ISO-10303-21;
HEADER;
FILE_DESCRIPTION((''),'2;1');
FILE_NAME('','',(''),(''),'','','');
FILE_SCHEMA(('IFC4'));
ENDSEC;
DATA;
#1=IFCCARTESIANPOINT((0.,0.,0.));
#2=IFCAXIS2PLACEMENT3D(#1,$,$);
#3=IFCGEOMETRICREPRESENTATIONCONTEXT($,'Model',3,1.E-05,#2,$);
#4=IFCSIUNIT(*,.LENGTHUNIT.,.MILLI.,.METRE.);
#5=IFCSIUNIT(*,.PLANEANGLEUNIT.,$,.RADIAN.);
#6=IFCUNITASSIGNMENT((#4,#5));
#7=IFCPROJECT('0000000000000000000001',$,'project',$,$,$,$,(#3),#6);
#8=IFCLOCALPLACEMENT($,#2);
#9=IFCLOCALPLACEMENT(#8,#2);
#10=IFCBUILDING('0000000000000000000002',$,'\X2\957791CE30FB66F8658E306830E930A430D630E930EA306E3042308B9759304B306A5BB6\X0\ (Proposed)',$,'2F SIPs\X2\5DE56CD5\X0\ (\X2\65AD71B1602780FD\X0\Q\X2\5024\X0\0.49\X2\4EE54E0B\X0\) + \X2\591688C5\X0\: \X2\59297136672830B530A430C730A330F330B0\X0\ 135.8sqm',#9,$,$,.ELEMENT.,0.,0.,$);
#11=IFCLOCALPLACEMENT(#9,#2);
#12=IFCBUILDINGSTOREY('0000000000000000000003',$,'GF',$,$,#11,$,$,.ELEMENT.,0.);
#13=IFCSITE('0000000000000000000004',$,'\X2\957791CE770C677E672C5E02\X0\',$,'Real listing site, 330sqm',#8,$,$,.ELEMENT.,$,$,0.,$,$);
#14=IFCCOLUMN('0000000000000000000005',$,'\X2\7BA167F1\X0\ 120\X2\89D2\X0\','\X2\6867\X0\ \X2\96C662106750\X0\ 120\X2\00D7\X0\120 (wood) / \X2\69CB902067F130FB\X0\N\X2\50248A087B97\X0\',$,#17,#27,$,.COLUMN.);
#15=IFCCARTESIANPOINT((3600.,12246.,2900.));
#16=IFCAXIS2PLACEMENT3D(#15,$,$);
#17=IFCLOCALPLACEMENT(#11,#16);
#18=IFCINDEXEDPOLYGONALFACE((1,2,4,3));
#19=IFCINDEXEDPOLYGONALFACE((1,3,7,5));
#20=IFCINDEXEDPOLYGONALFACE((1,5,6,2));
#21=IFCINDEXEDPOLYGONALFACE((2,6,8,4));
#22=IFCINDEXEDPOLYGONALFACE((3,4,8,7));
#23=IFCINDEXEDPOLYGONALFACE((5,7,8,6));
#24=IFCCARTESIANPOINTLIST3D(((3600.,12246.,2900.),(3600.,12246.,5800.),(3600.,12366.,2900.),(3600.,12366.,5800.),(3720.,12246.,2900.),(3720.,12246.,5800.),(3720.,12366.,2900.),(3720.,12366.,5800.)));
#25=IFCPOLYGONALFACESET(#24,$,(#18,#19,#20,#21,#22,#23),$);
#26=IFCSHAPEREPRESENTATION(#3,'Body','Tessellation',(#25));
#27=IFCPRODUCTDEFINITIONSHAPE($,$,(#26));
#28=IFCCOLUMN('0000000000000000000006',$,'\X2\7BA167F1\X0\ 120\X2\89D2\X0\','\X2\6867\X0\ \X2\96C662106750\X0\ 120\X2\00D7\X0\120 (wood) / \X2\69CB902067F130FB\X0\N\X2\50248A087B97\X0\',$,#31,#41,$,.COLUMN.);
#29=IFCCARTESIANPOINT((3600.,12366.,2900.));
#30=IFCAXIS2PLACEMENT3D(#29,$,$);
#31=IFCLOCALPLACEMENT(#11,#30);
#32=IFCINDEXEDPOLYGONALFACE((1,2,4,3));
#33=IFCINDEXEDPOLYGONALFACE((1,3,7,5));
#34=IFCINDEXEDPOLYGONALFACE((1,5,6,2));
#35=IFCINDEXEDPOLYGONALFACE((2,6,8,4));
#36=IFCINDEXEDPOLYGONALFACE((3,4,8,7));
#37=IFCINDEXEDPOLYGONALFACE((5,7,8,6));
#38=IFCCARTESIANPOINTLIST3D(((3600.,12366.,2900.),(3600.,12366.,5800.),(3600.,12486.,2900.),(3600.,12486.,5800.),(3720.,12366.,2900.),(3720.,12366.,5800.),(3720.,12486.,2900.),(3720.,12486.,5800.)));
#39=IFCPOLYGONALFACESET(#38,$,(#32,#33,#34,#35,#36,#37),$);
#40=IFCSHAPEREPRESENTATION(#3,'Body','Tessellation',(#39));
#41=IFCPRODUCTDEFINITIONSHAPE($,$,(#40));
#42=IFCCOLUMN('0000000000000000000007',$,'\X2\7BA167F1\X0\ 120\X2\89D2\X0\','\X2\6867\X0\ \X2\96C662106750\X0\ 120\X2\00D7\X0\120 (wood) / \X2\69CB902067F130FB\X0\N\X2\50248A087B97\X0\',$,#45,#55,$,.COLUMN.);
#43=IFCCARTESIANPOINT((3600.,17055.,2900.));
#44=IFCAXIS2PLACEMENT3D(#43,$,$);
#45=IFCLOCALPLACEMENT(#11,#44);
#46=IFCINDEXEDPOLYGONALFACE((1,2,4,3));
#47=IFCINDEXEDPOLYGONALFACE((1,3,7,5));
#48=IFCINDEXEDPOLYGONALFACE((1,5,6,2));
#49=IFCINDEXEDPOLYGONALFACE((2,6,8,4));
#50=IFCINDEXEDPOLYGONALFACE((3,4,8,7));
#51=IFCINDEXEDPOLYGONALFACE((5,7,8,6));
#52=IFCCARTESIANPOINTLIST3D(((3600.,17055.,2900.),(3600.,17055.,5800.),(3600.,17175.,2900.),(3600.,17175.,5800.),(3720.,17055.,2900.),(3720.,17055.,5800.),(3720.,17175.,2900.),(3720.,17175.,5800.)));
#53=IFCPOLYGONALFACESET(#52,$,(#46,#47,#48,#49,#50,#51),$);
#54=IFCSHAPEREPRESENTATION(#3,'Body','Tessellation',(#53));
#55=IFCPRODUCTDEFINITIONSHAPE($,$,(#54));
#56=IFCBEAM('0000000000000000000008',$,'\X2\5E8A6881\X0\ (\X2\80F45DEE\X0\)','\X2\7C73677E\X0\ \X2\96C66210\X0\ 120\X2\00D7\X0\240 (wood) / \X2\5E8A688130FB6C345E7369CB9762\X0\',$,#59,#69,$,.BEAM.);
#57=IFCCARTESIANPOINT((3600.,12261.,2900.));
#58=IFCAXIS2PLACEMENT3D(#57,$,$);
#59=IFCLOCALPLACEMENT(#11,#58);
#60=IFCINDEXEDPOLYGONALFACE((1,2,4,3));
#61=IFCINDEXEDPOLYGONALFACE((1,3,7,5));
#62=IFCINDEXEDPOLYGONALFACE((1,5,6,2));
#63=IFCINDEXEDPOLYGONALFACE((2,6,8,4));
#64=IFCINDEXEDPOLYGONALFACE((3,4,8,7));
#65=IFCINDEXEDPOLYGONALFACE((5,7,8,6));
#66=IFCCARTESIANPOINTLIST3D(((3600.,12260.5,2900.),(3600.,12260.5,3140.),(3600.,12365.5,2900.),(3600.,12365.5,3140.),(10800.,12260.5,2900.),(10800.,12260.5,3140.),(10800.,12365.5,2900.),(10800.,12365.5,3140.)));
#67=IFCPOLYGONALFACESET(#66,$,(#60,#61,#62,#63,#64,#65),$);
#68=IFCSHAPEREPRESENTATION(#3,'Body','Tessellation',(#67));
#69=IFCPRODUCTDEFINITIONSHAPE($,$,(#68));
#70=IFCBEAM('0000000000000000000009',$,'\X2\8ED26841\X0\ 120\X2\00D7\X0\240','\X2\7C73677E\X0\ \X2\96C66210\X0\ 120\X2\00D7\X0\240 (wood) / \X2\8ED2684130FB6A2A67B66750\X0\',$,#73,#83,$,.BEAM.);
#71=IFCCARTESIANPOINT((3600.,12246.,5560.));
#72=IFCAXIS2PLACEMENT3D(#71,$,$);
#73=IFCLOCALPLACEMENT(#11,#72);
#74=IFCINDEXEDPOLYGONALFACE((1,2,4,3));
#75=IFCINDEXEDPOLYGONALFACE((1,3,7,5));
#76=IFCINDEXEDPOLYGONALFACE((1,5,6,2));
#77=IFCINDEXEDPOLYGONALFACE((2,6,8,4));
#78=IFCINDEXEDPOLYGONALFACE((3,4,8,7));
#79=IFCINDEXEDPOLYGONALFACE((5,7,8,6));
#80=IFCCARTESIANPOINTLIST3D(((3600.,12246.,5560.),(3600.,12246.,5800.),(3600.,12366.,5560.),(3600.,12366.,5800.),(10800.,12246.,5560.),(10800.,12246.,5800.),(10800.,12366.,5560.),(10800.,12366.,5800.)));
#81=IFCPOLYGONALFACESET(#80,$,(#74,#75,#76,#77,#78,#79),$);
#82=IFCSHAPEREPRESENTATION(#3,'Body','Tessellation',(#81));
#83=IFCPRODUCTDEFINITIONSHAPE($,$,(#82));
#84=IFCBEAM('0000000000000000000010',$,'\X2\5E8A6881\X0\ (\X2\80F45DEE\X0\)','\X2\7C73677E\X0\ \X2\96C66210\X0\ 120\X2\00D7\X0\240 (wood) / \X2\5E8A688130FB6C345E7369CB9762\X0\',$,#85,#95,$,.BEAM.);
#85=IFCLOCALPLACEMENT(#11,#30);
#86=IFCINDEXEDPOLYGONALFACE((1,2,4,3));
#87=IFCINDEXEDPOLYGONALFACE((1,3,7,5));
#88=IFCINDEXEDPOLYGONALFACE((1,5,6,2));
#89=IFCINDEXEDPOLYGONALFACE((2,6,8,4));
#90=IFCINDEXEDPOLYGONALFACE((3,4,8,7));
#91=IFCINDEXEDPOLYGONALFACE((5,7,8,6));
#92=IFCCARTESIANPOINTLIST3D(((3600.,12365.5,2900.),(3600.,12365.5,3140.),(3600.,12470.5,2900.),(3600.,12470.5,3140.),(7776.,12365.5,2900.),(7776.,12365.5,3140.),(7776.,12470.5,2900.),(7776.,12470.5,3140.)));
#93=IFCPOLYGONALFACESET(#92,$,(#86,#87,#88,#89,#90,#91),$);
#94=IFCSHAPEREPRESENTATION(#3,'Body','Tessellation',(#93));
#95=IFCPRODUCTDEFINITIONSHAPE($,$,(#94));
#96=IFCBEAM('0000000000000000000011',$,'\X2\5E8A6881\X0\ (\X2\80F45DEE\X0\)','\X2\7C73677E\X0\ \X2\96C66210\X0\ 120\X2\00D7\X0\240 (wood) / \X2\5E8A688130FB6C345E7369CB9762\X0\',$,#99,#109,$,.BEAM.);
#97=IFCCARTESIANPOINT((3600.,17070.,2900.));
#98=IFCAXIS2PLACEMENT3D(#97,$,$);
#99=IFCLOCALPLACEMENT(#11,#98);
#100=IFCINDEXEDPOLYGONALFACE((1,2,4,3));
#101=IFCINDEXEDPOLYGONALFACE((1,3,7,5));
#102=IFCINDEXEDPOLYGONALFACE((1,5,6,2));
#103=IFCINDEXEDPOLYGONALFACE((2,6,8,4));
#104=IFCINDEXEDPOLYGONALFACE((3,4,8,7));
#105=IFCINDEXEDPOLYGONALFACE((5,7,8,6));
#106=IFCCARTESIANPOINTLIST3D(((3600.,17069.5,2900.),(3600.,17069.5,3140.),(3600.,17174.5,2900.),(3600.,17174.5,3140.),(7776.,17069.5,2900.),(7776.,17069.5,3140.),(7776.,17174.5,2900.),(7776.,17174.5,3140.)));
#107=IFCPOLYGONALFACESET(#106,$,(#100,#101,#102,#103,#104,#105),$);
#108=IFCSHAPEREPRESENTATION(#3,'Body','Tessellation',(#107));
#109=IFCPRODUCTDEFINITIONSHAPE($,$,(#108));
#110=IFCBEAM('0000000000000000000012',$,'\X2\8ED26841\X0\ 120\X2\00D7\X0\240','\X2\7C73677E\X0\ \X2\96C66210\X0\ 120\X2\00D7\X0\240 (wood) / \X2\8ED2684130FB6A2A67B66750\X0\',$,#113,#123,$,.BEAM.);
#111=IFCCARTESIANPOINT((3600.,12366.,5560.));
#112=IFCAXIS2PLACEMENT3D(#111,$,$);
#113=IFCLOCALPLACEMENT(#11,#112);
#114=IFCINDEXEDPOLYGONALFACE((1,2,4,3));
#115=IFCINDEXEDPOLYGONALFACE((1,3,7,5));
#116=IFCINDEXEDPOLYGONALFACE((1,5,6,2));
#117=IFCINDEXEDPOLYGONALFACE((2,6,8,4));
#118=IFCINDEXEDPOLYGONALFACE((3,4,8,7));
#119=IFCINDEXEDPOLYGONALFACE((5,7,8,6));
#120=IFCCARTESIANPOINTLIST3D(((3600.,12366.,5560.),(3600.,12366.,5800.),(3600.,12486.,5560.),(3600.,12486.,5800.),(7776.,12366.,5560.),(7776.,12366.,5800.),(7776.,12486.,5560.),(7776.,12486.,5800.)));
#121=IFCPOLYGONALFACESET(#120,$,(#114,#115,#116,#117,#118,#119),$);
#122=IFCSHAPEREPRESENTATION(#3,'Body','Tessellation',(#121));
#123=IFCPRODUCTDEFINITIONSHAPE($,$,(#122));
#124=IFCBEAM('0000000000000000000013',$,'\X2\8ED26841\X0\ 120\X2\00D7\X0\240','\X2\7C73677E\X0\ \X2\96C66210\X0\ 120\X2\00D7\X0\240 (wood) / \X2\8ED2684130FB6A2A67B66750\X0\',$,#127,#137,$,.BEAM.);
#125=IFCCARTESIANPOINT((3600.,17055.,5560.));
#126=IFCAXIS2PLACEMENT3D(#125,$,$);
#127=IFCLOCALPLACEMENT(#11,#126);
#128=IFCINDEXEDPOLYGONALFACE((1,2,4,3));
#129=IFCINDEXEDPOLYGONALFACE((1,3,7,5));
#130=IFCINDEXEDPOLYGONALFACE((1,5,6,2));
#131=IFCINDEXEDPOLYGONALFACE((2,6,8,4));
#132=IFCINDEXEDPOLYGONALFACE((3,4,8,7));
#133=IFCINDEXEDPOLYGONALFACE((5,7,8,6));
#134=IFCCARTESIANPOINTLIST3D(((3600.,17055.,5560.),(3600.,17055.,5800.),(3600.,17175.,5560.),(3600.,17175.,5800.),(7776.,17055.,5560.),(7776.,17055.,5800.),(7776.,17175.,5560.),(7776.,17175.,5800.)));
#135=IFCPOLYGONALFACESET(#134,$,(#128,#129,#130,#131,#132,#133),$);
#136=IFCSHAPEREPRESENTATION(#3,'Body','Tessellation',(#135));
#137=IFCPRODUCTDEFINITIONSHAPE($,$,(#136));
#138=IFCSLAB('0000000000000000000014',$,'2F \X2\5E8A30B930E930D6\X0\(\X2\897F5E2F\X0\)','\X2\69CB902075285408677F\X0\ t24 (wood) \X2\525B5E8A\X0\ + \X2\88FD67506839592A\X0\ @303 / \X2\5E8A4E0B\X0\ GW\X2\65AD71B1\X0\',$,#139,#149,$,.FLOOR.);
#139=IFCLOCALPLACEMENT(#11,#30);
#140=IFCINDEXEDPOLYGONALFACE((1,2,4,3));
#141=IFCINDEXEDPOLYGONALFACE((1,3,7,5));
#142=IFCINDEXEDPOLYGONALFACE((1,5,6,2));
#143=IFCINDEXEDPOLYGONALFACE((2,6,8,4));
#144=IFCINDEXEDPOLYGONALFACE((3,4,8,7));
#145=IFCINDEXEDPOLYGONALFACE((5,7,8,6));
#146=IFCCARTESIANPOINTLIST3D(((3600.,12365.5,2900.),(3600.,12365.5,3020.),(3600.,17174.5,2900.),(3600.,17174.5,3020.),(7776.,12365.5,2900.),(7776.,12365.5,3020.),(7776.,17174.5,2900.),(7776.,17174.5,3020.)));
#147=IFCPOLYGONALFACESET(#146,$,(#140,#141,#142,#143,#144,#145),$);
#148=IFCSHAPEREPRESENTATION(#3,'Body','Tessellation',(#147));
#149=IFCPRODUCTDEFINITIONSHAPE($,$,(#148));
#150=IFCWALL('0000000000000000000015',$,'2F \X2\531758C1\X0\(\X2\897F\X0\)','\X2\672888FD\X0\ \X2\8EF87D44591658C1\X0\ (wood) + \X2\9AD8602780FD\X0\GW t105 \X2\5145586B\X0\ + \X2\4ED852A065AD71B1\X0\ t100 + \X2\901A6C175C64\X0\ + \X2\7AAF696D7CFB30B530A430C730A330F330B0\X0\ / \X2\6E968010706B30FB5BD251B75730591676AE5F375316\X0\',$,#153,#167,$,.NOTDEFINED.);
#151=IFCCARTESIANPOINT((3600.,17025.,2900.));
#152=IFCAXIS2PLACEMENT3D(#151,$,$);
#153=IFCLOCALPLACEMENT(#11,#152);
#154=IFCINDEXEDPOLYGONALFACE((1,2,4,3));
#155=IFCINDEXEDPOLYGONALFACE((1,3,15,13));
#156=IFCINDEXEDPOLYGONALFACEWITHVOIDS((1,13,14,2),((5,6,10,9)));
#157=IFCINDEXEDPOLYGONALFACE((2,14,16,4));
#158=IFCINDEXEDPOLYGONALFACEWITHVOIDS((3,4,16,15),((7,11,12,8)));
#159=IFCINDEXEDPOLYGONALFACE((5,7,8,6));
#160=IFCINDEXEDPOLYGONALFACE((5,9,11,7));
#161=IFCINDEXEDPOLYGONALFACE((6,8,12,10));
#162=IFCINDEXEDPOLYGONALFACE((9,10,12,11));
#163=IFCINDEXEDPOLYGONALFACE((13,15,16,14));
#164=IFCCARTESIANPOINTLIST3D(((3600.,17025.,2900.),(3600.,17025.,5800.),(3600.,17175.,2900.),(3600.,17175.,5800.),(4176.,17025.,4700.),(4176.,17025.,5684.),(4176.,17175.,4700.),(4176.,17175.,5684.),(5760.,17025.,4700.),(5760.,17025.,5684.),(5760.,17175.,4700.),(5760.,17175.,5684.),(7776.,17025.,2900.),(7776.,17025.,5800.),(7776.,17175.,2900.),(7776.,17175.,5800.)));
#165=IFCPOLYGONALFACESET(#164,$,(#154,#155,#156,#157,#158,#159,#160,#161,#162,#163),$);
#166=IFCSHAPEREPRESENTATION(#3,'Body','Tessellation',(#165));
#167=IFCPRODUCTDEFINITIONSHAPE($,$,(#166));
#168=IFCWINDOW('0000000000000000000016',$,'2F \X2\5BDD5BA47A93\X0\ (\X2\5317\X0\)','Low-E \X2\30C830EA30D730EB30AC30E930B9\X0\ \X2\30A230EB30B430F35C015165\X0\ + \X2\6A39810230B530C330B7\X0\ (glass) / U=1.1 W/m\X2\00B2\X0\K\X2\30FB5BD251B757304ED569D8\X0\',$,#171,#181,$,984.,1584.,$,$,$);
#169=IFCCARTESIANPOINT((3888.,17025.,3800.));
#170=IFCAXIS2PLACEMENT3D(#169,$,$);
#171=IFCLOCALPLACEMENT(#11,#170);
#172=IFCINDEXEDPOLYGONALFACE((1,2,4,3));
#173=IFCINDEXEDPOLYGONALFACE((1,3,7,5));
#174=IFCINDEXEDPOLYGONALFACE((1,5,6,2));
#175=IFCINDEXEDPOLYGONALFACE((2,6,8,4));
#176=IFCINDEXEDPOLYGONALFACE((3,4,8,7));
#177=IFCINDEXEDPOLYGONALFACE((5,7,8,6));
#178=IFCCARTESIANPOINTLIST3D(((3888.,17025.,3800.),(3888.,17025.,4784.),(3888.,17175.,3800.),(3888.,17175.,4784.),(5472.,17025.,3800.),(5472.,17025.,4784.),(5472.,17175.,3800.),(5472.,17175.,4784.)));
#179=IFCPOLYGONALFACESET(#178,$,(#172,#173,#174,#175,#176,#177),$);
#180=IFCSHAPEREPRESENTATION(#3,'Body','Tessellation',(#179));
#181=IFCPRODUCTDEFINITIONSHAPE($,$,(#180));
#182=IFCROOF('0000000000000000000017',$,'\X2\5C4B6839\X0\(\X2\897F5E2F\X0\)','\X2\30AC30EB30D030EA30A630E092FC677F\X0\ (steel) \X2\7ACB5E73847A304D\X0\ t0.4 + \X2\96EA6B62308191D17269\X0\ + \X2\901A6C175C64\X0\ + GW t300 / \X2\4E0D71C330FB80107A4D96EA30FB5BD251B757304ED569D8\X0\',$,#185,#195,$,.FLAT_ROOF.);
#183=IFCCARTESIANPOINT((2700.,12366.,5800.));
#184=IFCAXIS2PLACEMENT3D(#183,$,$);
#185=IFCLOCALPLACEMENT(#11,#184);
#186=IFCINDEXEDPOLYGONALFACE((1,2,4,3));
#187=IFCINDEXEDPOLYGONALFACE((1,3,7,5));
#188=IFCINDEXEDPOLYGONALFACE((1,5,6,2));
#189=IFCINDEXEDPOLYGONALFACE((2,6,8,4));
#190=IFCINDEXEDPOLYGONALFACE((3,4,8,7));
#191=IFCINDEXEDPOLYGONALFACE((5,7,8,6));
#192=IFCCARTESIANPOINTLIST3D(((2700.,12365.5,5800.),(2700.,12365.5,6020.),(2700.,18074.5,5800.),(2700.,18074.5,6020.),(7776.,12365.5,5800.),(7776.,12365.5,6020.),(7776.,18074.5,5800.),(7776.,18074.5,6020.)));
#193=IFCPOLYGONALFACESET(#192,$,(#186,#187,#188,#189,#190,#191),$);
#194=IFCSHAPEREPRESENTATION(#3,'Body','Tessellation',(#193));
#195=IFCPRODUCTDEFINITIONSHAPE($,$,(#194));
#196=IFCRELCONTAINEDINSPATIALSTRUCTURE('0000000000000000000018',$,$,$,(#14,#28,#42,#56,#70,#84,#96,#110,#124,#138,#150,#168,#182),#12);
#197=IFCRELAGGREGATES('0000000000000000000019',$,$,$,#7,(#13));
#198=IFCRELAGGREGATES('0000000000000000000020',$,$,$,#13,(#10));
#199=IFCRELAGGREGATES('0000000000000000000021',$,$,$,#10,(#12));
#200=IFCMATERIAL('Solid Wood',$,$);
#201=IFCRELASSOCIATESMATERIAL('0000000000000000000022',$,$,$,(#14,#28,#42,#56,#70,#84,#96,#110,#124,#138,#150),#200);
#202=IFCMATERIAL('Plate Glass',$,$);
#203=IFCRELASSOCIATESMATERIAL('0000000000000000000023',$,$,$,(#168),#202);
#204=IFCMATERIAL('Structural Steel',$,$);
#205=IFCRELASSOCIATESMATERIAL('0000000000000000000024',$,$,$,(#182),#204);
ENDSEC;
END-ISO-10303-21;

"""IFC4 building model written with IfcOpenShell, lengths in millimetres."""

from ifc_helpers import new_model, si_unit, frame, frame_2d, origin, place, context, project, spatial, rectangle, extrude, material, element, fill, save


model = new_model("IFC4")

# Units and contexts
model_context = context("Model", 3, precision=1e-05, world=origin())
ifc_project = project(units=[si_unit("LENGTHUNIT", "METRE", prefix="MILLI"), si_unit("PLANEANGLEUNIT", "RADIAN")], contexts=[model_context])

# Site, building, storey
site_placement = place(None, origin())
site = spatial("IfcSite", under=ifc_project, at=site_placement, Name="長野県松本市", ObjectType="Real listing site, 330sqm", CompositionType="ELEMENT", RefElevation=0.0)
building_placement = place(site_placement, origin())
building = spatial("IfcBuilding", under=site, at=building_placement, Name="長野・書斎とライブラリのある静かな家 (Proposed)", ObjectType="2F SIPs工法 (断熱性能Q値0.49以下) + 外装: 天然木サイディング 135.8sqm", CompositionType="ELEMENT", ElevationOfRefHeight=0.0, ElevationOfTerrain=0.0)
storey_placement = place(building_placement, origin())
storey = spatial("IfcBuildingStorey", under=building, at=storey_placement, Name="GF", CompositionType="ELEMENT", Elevation=0.0)

# Columns
ifc_material_1 = material(Name="Solid Wood")
column_1_placement = place(storey_placement, frame((3600.0, 12246.0, 2900.0)))
element("IfcColumn", 1, at=column_1_placement, inside=storey, material=ifc_material_1, Name="管柱 120角", Description="桧 集成材 120×120 (wood) / 構造柱・N値計算", PredefinedType="COLUMN", context=model_context, shape_type="SweptSolid", body=[
    extrude(rectangle(XDim=120.0, YDim=120.0, at=frame_2d((60.0, 60.0))), frame((3600.0, 12246.0, 2900.0)), (0.0, 0.0, 1.0), 2900.0),
])
column_2_placement = place(storey_placement, frame((3600.0, 12366.0, 2900.0)))
element("IfcColumn", 2, at=column_2_placement, inside=storey, material=ifc_material_1, Name="管柱 120角", Description="桧 集成材 120×120 (wood) / 構造柱・N値計算", PredefinedType="COLUMN", context=model_context, shape_type="SweptSolid", body=[
    extrude(rectangle(XDim=120.0, YDim=120.0, at=frame_2d((60.0, 60.0))), frame((3600.0, 12366.0, 2900.0)), (0.0, 0.0, 1.0), 2900.0),
])
column_3_placement = place(storey_placement, frame((3600.0, 17055.0, 2900.0)))
element("IfcColumn", 3, at=column_3_placement, inside=storey, material=ifc_material_1, Name="管柱 120角", Description="桧 集成材 120×120 (wood) / 構造柱・N値計算", PredefinedType="COLUMN", context=model_context, shape_type="SweptSolid", body=[
    extrude(rectangle(XDim=120.0, YDim=120.0, at=frame_2d((60.0, 60.0))), frame((3600.0, 17055.0, 2900.0)), (0.0, 0.0, 1.0), 2900.0),
])

# Beams
beam_1_placement = place(storey_placement, frame((3600.0, 12261.0, 2900.0)))
element("IfcBeam", 4, at=beam_1_placement, inside=storey, material=ifc_material_1, Name="床梁 (胴差)", Description="米松 集成 120×240 (wood) / 床梁・水平構面", PredefinedType="BEAM", context=model_context, shape_type="SweptSolid", body=[
    extrude(rectangle(XDim=7200.0, YDim=105.0, at=frame_2d((3600.0, 52.0))), frame((3600.0, 12261.0, 2900.0)), (0.0, 0.0, 1.0), 240.0),
])
beam_2_placement = place(storey_placement, frame((3600.0, 12246.0, 5560.0)))
element("IfcBeam", 5, at=beam_2_placement, inside=storey, material=ifc_material_1, Name="軒桁 120×240", Description="米松 集成 120×240 (wood) / 軒桁・横架材", PredefinedType="BEAM", context=model_context, shape_type="SweptSolid", body=[
    extrude(rectangle(XDim=7200.0, YDim=120.0, at=frame_2d((3600.0, 60.0))), frame((3600.0, 12246.0, 5560.0)), (0.0, 0.0, 1.0), 240.0),
])
beam_3_placement = place(storey_placement, frame((3600.0, 12366.0, 2900.0)))
element("IfcBeam", 6, at=beam_3_placement, inside=storey, material=ifc_material_1, Name="床梁 (胴差)", Description="米松 集成 120×240 (wood) / 床梁・水平構面", PredefinedType="BEAM", context=model_context, shape_type="SweptSolid", body=[
    extrude(rectangle(XDim=4176.0, YDim=105.0, at=frame_2d((2088.0, 52.0))), frame((3600.0, 12366.0, 2900.0)), (0.0, 0.0, 1.0), 240.0),
])
beam_4_placement = place(storey_placement, frame((3600.0, 17070.0, 2900.0)))
element("IfcBeam", 7, at=beam_4_placement, inside=storey, material=ifc_material_1, Name="床梁 (胴差)", Description="米松 集成 120×240 (wood) / 床梁・水平構面", PredefinedType="BEAM", context=model_context, shape_type="SweptSolid", body=[
    extrude(rectangle(XDim=4176.0, YDim=105.0, at=frame_2d((2088.0, 52.0))), frame((3600.0, 17070.0, 2900.0)), (0.0, 0.0, 1.0), 240.0),
])
beam_5_placement = place(storey_placement, frame((3600.0, 12366.0, 5560.0)))
element("IfcBeam", 8, at=beam_5_placement, inside=storey, material=ifc_material_1, Name="軒桁 120×240", Description="米松 集成 120×240 (wood) / 軒桁・横架材", PredefinedType="BEAM", context=model_context, shape_type="SweptSolid", body=[
    extrude(rectangle(XDim=4176.0, YDim=120.0, at=frame_2d((2088.0, 60.0))), frame((3600.0, 12366.0, 5560.0)), (0.0, 0.0, 1.0), 240.0),
])
beam_6_placement = place(storey_placement, frame((3600.0, 17055.0, 5560.0)))
element("IfcBeam", 9, at=beam_6_placement, inside=storey, material=ifc_material_1, Name="軒桁 120×240", Description="米松 集成 120×240 (wood) / 軒桁・横架材", PredefinedType="BEAM", context=model_context, shape_type="SweptSolid", body=[
    extrude(rectangle(XDim=4176.0, YDim=120.0, at=frame_2d((2088.0, 60.0))), frame((3600.0, 17055.0, 5560.0)), (0.0, 0.0, 1.0), 240.0),
])

# Slab
slab_placement = place(storey_placement, frame((3600.0, 12366.0, 2900.0)))
element("IfcSlab", 10, at=slab_placement, inside=storey, material=ifc_material_1, Name="2F 床スラブ(西帯)", Description="構造用合板 t24 (wood) 剛床 + 製材根太 @303 / 床下 GW断熱", PredefinedType="FLOOR", context=model_context, shape_type="SweptSolid", body=[
    extrude(rectangle(XDim=4176.0, YDim=4809.0, at=frame_2d((2088.0, 2404.0))), frame((3600.0, 12366.0, 2900.0)), (0.0, 0.0, 1.0), 120.0),
])

# Wall, opening, window
wall_1_placement = place(storey_placement, frame((3600.0, 17025.0, 2900.0)))
wall_1 = element("IfcWall", 11, at=wall_1_placement, inside=storey, material=ifc_material_1, Name="2F 北壁(西)", Description="木製 軸組外壁 (wood) + 高性能GW t105 充填 + 付加断熱 t100 + 通気層 + 窯業系サイディング / 準耐火・寒冷地外皮強化", PredefinedType="NOTDEFINED", context=model_context, shape_type="SweptSolid", body=[
    extrude(rectangle(XDim=4176.0, YDim=150.0, at=frame_2d((2088.0, 75.0))), frame((3600.0, 17025.0, 2900.0)), (0.0, 0.0, 1.0), 2900.0),
])
opening_placement = place(storey_placement, frame((3888.0, 17025.0, 3800.0)))
opening = element("IfcOpeningElement", 12, at=opening_placement, cuts=wall_1, PredefinedType="NOTDEFINED", context=model_context, shape_type="SweptSolid", body=[
    extrude(rectangle(XDim=1584.0, YDim=150.0, at=frame_2d((792.0, 75.0))), frame((3888.0, 17025.0, 3800.0)), (0.0, 0.0, 1.0), 984.0),
])
ifc_material_2 = material(Name="Plate Glass")
window_placement = place(storey_placement, frame((3888.0, 17025.0, 3800.0)))
window = element("IfcWindow", 13, at=window_placement, inside=storey, material=ifc_material_2, Name="2F 寝室窓 (北)", Description="Low-E トリプルガラス アルゴン封入 + 樹脂サッシ (glass) / U=1.1 W/m²K・寒冷地仕様", OverallHeight=984.0, OverallWidth=1584.0, context=model_context, shape_type="SweptSolid", body=[
    extrude(rectangle(XDim=1584.0, YDim=150.0, at=frame_2d((792.0, 75.0))), frame((3888.0, 17025.0, 3800.0)), (0.0, 0.0, 1.0), 984.0),
])
fill(opening, window)

# Roof
ifc_material_3 = material(Name="Structural Steel")
for number, where, name in (
    (14, (2700.0, 12366.0, 5800.0), "屋根(西帯)"),
):
    element("IfcRoof", number, at=place(storey_placement, frame(where)), inside=storey, material=ifc_material_3, Name=name, Description="ガルバリウム鋼板 (steel) 立平葺き t0.4 + 雪止め金物 + 通気層 + GW t300 / 不燃・耐積雪・寒冷地仕様", PredefinedType="FLAT_ROOF", context=model_context, shape_type="SweptSolid", body=[
        extrude(rectangle(XDim=5076.0, YDim=5709.0, at=frame_2d((2538.0, 2854.0))), frame((2700.0, 12366.0, 5800.0)), (0.0, 0.0, 1.0), 220.0),
    ])

save(model, "model.ifc")
